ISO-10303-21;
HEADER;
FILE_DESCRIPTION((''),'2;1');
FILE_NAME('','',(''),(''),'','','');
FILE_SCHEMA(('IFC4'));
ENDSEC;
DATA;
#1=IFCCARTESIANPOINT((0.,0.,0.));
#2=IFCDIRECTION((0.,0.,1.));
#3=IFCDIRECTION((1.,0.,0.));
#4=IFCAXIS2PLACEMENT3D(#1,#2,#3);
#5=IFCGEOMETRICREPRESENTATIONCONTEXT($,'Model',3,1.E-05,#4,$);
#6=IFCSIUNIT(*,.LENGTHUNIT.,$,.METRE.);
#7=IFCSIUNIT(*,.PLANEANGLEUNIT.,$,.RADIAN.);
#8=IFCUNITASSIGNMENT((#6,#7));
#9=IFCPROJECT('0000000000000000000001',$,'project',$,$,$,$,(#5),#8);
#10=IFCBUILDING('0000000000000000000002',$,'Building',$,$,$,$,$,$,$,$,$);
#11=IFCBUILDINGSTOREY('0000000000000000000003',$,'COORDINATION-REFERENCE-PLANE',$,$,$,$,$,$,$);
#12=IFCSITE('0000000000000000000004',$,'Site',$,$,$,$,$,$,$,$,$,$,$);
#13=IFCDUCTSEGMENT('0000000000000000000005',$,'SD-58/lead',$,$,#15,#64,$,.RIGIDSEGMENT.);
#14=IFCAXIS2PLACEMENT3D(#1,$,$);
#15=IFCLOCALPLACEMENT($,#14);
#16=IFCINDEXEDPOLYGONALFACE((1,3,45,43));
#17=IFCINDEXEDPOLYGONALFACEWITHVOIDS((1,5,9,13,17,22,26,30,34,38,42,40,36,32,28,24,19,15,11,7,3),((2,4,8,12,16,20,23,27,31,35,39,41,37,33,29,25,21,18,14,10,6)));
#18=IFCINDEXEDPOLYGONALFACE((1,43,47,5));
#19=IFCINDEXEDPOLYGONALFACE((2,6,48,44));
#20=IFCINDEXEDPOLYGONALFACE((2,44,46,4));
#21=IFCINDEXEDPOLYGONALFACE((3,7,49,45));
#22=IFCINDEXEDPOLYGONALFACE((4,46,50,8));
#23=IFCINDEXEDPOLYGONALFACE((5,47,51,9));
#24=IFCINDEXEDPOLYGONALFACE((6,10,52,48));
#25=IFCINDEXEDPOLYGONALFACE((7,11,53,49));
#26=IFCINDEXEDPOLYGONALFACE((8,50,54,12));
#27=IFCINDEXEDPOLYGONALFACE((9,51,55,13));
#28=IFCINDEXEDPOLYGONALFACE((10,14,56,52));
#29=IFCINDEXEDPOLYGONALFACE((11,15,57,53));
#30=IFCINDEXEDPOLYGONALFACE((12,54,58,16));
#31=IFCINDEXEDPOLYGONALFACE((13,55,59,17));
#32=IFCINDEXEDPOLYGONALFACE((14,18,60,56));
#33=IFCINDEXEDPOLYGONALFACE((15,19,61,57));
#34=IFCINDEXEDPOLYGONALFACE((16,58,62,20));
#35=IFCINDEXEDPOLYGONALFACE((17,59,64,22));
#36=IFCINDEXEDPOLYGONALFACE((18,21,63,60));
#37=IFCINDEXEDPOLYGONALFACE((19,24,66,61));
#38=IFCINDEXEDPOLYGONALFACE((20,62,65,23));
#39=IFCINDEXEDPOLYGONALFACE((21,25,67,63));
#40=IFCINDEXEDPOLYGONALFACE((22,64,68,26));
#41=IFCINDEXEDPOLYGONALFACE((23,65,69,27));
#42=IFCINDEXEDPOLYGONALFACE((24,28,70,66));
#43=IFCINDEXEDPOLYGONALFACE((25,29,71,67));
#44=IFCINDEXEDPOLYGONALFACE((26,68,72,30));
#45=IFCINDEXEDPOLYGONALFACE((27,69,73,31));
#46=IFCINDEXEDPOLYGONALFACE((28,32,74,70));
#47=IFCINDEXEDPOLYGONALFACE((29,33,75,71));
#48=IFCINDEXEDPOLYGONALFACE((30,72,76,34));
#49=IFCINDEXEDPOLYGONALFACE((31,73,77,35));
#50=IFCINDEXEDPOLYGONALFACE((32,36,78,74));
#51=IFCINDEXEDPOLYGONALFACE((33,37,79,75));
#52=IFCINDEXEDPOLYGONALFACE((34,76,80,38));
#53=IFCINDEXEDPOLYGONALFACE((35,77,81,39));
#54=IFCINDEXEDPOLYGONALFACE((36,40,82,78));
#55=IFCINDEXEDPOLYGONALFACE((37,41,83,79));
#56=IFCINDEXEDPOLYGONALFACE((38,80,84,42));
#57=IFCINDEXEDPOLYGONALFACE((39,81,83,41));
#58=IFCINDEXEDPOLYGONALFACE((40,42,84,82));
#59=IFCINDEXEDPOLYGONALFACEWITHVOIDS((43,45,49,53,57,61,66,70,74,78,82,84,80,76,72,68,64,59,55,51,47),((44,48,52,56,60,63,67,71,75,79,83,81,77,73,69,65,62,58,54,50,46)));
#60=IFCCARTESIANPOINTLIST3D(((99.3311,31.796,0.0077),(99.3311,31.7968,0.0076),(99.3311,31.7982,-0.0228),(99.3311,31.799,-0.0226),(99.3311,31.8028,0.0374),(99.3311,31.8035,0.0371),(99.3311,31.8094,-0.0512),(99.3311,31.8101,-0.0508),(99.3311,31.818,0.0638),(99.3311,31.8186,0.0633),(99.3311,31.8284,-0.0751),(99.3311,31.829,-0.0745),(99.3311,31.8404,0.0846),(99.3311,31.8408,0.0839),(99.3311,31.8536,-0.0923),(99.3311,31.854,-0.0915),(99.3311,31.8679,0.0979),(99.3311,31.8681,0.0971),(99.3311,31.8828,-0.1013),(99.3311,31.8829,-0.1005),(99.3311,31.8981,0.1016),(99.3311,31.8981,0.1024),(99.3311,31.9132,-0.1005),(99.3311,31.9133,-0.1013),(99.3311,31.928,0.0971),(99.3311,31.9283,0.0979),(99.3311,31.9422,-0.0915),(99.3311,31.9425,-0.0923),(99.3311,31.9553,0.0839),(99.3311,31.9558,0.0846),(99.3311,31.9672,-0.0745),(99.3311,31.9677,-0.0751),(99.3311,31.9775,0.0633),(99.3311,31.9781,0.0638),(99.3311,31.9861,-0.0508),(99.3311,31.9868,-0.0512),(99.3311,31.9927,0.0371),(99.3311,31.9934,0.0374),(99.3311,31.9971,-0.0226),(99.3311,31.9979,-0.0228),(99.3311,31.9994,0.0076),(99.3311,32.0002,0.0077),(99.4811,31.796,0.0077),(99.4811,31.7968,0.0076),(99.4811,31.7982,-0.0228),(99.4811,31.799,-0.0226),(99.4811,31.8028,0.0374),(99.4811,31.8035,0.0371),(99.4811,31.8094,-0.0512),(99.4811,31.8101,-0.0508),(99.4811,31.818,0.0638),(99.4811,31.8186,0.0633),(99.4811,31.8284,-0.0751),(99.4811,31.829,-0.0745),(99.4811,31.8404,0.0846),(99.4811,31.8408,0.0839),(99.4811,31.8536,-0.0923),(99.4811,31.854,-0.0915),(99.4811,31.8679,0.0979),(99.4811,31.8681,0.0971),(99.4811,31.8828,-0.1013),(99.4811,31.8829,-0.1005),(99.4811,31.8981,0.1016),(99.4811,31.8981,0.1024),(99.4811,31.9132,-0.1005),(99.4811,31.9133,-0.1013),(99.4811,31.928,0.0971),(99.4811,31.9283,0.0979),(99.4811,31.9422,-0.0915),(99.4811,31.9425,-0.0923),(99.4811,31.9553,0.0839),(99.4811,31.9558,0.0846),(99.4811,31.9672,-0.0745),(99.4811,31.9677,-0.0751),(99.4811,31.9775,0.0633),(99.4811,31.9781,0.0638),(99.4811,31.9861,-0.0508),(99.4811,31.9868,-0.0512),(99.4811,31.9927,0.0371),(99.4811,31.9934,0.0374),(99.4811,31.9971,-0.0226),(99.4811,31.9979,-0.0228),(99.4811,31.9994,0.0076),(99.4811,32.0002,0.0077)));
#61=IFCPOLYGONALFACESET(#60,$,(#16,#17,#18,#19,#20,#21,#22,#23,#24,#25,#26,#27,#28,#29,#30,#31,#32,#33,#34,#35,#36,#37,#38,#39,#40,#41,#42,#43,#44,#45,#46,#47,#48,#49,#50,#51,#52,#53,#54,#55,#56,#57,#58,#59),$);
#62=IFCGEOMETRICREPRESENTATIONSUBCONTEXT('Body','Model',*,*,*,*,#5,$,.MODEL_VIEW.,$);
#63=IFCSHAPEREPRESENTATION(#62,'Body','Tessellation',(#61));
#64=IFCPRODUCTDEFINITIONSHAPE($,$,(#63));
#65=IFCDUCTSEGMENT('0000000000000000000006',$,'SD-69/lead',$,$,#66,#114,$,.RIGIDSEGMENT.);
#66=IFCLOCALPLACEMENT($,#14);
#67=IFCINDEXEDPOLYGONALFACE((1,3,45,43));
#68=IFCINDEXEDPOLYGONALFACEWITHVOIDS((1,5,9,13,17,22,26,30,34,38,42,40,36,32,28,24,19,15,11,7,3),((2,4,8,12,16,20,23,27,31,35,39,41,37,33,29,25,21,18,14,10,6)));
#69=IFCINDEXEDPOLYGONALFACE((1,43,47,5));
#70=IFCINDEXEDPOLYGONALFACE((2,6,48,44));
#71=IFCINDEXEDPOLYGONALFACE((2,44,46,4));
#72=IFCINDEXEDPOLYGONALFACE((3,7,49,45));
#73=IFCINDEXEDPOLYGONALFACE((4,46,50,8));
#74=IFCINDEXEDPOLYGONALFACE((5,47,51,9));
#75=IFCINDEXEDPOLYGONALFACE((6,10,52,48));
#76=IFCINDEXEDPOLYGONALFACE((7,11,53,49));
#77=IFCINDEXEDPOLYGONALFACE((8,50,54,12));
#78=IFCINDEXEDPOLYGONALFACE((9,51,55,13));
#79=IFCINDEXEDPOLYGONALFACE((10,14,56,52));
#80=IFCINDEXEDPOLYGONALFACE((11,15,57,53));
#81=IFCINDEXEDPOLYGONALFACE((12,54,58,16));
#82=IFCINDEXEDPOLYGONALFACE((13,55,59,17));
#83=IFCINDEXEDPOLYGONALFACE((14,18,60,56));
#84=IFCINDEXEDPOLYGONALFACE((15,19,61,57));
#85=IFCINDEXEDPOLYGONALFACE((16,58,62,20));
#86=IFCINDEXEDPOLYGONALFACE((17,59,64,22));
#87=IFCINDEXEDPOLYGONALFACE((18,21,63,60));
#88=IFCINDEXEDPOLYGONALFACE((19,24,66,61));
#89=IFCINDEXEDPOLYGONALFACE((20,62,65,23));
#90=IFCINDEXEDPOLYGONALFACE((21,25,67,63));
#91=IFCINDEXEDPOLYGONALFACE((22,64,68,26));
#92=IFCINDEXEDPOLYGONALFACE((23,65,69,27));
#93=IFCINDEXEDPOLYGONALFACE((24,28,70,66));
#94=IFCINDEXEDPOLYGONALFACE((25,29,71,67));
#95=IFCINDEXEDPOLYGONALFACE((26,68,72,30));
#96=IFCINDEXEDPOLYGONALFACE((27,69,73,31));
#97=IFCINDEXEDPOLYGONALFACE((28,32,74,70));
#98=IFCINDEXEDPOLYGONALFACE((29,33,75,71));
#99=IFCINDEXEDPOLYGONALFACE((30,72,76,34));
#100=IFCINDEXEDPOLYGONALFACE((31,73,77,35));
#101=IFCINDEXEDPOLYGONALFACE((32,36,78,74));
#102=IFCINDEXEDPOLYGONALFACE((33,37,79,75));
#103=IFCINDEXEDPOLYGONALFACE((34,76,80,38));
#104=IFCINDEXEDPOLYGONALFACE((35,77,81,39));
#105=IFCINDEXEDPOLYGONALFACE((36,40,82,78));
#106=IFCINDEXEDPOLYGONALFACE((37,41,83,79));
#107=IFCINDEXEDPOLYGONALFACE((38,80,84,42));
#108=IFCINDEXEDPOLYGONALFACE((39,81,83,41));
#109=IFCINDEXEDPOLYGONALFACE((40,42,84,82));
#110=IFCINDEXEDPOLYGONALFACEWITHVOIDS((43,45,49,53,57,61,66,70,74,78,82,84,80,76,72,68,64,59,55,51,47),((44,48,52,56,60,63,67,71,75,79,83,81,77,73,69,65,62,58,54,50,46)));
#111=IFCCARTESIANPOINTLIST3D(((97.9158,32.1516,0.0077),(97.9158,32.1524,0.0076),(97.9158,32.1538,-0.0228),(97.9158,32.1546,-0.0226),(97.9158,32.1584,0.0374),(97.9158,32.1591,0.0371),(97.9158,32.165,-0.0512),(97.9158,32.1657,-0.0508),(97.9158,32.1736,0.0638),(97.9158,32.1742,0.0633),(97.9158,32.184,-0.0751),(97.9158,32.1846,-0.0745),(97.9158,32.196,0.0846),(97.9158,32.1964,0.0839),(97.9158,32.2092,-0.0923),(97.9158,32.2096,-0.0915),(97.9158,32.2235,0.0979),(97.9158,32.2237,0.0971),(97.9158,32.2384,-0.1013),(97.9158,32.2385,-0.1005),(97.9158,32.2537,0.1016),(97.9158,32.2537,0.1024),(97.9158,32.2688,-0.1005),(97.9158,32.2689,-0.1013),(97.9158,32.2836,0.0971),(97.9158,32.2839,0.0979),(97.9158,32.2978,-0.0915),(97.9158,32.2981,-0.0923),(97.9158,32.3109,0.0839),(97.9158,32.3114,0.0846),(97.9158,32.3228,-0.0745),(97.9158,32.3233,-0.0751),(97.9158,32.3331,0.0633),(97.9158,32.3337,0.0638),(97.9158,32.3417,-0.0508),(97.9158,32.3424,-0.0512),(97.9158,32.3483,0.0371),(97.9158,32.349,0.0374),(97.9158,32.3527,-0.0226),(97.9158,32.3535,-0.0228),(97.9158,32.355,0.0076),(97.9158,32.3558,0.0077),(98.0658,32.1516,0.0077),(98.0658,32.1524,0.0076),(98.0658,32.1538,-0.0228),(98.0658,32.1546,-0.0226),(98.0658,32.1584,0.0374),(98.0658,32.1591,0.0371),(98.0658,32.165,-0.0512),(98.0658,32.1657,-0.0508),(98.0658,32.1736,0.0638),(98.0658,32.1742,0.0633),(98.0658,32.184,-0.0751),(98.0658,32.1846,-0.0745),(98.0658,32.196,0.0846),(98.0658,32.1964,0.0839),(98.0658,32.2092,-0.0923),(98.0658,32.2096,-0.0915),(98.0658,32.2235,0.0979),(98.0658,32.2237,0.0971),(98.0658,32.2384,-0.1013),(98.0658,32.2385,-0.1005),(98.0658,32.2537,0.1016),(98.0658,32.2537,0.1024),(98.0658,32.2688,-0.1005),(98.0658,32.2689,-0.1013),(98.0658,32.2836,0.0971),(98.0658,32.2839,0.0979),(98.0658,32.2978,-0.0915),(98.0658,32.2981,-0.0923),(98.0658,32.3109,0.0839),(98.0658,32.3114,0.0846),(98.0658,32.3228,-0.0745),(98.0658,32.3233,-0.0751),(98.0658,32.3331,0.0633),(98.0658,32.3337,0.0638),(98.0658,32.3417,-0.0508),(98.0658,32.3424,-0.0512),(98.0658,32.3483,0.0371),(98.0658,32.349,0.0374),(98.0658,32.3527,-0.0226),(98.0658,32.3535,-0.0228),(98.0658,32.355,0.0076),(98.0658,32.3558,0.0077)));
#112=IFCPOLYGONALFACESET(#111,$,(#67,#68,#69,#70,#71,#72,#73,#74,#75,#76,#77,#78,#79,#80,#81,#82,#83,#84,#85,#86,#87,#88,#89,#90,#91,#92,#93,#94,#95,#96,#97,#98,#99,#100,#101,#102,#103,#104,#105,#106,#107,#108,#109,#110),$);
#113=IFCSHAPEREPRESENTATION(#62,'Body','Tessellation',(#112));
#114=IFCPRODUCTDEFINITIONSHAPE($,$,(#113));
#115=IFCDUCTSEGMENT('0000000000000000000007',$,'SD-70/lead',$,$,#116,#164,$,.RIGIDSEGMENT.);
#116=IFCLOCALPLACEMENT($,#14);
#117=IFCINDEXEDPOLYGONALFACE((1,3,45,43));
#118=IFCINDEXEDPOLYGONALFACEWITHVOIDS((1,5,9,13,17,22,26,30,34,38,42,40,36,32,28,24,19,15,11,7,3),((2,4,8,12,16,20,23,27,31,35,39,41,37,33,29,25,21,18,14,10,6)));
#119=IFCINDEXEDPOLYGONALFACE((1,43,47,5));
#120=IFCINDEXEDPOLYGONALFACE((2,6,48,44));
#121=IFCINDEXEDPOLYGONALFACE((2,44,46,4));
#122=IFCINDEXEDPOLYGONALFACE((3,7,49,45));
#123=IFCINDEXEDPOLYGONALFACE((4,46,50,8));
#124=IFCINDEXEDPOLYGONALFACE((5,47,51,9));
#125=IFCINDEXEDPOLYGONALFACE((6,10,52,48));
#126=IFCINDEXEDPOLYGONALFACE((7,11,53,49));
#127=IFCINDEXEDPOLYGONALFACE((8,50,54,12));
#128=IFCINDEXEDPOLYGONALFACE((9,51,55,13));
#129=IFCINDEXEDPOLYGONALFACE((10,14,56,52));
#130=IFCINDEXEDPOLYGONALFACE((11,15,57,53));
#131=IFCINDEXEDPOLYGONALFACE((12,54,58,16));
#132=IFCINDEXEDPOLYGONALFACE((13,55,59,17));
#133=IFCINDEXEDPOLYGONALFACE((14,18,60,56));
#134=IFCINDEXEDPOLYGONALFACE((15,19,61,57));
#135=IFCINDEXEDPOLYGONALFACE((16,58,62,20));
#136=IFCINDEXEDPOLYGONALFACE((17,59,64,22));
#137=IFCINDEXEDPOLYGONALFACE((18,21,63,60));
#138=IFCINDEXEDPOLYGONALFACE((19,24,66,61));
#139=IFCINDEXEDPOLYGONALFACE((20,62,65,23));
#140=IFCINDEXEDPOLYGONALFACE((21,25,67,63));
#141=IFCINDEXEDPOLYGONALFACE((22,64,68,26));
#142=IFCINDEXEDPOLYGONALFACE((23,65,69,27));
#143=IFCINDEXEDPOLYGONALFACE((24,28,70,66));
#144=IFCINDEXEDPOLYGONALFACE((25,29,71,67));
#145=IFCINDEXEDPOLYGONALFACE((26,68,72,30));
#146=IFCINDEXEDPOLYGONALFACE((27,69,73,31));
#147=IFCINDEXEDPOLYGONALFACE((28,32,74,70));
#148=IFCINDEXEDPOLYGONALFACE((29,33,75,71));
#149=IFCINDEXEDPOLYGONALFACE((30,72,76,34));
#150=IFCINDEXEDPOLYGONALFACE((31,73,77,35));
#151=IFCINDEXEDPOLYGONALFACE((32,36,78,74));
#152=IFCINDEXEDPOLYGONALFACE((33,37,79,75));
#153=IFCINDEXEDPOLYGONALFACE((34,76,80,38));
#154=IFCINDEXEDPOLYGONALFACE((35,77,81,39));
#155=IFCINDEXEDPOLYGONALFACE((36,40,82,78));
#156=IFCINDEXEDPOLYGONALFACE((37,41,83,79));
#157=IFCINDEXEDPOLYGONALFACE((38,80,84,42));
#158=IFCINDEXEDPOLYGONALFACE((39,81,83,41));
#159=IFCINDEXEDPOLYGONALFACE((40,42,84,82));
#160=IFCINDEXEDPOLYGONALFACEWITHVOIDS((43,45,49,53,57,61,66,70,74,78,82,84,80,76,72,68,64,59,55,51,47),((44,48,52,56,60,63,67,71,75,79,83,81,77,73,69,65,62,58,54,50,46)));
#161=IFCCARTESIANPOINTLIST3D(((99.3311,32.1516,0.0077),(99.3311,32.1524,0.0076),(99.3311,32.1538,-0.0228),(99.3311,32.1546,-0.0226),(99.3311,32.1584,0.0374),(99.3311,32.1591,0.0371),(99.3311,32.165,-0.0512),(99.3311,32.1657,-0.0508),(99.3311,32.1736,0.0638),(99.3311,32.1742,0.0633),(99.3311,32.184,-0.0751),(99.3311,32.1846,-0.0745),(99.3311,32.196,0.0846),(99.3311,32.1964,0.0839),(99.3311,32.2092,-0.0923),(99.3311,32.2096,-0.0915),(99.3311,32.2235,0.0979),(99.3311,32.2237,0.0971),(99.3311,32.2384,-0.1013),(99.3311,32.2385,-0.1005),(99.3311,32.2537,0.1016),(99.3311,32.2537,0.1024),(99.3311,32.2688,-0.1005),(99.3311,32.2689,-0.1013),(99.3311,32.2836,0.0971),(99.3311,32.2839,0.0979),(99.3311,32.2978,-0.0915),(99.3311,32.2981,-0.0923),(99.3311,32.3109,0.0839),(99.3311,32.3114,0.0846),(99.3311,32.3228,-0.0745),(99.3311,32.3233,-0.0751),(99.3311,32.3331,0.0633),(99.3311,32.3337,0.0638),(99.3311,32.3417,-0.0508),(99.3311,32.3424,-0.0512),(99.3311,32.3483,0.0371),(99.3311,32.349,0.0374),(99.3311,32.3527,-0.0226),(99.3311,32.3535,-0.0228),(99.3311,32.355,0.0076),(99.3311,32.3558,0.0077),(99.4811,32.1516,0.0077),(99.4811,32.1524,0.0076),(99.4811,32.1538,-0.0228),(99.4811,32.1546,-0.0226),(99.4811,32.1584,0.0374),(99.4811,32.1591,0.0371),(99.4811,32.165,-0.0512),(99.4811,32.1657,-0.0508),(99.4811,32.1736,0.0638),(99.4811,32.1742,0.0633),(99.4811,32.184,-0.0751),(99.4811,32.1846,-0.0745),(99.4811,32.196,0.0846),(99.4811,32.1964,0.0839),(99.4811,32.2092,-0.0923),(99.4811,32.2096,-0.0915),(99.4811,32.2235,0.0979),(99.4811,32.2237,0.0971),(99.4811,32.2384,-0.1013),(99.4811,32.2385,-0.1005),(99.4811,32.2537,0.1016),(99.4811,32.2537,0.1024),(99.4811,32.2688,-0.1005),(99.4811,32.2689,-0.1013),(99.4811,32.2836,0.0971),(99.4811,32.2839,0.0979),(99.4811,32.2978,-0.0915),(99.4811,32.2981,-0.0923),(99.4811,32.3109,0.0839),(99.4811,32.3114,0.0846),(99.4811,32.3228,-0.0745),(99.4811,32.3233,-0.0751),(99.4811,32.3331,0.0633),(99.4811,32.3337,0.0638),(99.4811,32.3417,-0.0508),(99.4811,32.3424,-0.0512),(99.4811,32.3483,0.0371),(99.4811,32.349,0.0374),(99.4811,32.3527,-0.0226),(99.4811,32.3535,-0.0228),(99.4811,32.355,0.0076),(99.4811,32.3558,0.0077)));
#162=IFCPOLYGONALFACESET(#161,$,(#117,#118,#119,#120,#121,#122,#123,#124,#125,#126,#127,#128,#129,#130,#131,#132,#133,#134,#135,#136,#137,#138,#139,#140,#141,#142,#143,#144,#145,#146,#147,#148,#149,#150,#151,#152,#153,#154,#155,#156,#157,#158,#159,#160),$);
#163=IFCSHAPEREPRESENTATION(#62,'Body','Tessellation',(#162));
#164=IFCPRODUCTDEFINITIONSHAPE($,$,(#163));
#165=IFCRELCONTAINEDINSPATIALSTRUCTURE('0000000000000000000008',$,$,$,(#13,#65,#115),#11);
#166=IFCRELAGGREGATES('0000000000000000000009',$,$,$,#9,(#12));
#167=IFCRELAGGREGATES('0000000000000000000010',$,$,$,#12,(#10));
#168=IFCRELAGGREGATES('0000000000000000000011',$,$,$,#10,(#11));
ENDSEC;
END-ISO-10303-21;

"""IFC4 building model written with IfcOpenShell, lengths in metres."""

from ifc_helpers import new_model, si_unit, frame, origin_with_axes, place, context, subcontext, project, spatial, hollow_circle, extrude, element, save


model = new_model("IFC4")

# Units and contexts
model_context = context("Model", 3, precision=1e-05, world=origin_with_axes())
body_context_1 = subcontext(model_context, "Body", "Model", "MODEL_VIEW")
ifc_project = project(units=[si_unit("LENGTHUNIT", "METRE"), si_unit("PLANEANGLEUNIT", "RADIAN")], contexts=[model_context])

# Site, building, storey
site = spatial("IfcSite", under=ifc_project, Name="Site")
building = spatial("IfcBuilding", under=site, Name="Building")
storey = spatial("IfcBuildingStorey", under=building, Name="COORDINATION-REFERENCE-PLANE")

# Duct segments
for number, where, z_axis, x_axis, name in (
    (1, (99.3311, 31.8981, 0.0), (1.0, 0.0, 0.0), (0.0, 0.0, 1.0), "SD-58/lead"),
    (2, (98.0658, 32.2537, 0.0), (-1.0, 0.0, 0.0), (0.0, 0.0, 1.0), "SD-69/lead"),
    (3, (99.3311, 32.2537, 0.0), (1.0, 0.0, 0.0), (0.0, 0.0, 1.0), "SD-70/lead"),
):
    element("IfcDuctSegment", number, at=place(None, frame(where, z_axis=z_axis, x_axis=x_axis)), inside=storey, Name=name, PredefinedType="RIGIDSEGMENT", context=body_context_1, shape_type="SweptSolid", body=[
        extrude(hollow_circle(Radius=0.1024, WallThickness=0.0008), origin_with_axes(), (0.0, 0.0, 1.0), 0.15),
    ])

save(model, "model.ifc")
